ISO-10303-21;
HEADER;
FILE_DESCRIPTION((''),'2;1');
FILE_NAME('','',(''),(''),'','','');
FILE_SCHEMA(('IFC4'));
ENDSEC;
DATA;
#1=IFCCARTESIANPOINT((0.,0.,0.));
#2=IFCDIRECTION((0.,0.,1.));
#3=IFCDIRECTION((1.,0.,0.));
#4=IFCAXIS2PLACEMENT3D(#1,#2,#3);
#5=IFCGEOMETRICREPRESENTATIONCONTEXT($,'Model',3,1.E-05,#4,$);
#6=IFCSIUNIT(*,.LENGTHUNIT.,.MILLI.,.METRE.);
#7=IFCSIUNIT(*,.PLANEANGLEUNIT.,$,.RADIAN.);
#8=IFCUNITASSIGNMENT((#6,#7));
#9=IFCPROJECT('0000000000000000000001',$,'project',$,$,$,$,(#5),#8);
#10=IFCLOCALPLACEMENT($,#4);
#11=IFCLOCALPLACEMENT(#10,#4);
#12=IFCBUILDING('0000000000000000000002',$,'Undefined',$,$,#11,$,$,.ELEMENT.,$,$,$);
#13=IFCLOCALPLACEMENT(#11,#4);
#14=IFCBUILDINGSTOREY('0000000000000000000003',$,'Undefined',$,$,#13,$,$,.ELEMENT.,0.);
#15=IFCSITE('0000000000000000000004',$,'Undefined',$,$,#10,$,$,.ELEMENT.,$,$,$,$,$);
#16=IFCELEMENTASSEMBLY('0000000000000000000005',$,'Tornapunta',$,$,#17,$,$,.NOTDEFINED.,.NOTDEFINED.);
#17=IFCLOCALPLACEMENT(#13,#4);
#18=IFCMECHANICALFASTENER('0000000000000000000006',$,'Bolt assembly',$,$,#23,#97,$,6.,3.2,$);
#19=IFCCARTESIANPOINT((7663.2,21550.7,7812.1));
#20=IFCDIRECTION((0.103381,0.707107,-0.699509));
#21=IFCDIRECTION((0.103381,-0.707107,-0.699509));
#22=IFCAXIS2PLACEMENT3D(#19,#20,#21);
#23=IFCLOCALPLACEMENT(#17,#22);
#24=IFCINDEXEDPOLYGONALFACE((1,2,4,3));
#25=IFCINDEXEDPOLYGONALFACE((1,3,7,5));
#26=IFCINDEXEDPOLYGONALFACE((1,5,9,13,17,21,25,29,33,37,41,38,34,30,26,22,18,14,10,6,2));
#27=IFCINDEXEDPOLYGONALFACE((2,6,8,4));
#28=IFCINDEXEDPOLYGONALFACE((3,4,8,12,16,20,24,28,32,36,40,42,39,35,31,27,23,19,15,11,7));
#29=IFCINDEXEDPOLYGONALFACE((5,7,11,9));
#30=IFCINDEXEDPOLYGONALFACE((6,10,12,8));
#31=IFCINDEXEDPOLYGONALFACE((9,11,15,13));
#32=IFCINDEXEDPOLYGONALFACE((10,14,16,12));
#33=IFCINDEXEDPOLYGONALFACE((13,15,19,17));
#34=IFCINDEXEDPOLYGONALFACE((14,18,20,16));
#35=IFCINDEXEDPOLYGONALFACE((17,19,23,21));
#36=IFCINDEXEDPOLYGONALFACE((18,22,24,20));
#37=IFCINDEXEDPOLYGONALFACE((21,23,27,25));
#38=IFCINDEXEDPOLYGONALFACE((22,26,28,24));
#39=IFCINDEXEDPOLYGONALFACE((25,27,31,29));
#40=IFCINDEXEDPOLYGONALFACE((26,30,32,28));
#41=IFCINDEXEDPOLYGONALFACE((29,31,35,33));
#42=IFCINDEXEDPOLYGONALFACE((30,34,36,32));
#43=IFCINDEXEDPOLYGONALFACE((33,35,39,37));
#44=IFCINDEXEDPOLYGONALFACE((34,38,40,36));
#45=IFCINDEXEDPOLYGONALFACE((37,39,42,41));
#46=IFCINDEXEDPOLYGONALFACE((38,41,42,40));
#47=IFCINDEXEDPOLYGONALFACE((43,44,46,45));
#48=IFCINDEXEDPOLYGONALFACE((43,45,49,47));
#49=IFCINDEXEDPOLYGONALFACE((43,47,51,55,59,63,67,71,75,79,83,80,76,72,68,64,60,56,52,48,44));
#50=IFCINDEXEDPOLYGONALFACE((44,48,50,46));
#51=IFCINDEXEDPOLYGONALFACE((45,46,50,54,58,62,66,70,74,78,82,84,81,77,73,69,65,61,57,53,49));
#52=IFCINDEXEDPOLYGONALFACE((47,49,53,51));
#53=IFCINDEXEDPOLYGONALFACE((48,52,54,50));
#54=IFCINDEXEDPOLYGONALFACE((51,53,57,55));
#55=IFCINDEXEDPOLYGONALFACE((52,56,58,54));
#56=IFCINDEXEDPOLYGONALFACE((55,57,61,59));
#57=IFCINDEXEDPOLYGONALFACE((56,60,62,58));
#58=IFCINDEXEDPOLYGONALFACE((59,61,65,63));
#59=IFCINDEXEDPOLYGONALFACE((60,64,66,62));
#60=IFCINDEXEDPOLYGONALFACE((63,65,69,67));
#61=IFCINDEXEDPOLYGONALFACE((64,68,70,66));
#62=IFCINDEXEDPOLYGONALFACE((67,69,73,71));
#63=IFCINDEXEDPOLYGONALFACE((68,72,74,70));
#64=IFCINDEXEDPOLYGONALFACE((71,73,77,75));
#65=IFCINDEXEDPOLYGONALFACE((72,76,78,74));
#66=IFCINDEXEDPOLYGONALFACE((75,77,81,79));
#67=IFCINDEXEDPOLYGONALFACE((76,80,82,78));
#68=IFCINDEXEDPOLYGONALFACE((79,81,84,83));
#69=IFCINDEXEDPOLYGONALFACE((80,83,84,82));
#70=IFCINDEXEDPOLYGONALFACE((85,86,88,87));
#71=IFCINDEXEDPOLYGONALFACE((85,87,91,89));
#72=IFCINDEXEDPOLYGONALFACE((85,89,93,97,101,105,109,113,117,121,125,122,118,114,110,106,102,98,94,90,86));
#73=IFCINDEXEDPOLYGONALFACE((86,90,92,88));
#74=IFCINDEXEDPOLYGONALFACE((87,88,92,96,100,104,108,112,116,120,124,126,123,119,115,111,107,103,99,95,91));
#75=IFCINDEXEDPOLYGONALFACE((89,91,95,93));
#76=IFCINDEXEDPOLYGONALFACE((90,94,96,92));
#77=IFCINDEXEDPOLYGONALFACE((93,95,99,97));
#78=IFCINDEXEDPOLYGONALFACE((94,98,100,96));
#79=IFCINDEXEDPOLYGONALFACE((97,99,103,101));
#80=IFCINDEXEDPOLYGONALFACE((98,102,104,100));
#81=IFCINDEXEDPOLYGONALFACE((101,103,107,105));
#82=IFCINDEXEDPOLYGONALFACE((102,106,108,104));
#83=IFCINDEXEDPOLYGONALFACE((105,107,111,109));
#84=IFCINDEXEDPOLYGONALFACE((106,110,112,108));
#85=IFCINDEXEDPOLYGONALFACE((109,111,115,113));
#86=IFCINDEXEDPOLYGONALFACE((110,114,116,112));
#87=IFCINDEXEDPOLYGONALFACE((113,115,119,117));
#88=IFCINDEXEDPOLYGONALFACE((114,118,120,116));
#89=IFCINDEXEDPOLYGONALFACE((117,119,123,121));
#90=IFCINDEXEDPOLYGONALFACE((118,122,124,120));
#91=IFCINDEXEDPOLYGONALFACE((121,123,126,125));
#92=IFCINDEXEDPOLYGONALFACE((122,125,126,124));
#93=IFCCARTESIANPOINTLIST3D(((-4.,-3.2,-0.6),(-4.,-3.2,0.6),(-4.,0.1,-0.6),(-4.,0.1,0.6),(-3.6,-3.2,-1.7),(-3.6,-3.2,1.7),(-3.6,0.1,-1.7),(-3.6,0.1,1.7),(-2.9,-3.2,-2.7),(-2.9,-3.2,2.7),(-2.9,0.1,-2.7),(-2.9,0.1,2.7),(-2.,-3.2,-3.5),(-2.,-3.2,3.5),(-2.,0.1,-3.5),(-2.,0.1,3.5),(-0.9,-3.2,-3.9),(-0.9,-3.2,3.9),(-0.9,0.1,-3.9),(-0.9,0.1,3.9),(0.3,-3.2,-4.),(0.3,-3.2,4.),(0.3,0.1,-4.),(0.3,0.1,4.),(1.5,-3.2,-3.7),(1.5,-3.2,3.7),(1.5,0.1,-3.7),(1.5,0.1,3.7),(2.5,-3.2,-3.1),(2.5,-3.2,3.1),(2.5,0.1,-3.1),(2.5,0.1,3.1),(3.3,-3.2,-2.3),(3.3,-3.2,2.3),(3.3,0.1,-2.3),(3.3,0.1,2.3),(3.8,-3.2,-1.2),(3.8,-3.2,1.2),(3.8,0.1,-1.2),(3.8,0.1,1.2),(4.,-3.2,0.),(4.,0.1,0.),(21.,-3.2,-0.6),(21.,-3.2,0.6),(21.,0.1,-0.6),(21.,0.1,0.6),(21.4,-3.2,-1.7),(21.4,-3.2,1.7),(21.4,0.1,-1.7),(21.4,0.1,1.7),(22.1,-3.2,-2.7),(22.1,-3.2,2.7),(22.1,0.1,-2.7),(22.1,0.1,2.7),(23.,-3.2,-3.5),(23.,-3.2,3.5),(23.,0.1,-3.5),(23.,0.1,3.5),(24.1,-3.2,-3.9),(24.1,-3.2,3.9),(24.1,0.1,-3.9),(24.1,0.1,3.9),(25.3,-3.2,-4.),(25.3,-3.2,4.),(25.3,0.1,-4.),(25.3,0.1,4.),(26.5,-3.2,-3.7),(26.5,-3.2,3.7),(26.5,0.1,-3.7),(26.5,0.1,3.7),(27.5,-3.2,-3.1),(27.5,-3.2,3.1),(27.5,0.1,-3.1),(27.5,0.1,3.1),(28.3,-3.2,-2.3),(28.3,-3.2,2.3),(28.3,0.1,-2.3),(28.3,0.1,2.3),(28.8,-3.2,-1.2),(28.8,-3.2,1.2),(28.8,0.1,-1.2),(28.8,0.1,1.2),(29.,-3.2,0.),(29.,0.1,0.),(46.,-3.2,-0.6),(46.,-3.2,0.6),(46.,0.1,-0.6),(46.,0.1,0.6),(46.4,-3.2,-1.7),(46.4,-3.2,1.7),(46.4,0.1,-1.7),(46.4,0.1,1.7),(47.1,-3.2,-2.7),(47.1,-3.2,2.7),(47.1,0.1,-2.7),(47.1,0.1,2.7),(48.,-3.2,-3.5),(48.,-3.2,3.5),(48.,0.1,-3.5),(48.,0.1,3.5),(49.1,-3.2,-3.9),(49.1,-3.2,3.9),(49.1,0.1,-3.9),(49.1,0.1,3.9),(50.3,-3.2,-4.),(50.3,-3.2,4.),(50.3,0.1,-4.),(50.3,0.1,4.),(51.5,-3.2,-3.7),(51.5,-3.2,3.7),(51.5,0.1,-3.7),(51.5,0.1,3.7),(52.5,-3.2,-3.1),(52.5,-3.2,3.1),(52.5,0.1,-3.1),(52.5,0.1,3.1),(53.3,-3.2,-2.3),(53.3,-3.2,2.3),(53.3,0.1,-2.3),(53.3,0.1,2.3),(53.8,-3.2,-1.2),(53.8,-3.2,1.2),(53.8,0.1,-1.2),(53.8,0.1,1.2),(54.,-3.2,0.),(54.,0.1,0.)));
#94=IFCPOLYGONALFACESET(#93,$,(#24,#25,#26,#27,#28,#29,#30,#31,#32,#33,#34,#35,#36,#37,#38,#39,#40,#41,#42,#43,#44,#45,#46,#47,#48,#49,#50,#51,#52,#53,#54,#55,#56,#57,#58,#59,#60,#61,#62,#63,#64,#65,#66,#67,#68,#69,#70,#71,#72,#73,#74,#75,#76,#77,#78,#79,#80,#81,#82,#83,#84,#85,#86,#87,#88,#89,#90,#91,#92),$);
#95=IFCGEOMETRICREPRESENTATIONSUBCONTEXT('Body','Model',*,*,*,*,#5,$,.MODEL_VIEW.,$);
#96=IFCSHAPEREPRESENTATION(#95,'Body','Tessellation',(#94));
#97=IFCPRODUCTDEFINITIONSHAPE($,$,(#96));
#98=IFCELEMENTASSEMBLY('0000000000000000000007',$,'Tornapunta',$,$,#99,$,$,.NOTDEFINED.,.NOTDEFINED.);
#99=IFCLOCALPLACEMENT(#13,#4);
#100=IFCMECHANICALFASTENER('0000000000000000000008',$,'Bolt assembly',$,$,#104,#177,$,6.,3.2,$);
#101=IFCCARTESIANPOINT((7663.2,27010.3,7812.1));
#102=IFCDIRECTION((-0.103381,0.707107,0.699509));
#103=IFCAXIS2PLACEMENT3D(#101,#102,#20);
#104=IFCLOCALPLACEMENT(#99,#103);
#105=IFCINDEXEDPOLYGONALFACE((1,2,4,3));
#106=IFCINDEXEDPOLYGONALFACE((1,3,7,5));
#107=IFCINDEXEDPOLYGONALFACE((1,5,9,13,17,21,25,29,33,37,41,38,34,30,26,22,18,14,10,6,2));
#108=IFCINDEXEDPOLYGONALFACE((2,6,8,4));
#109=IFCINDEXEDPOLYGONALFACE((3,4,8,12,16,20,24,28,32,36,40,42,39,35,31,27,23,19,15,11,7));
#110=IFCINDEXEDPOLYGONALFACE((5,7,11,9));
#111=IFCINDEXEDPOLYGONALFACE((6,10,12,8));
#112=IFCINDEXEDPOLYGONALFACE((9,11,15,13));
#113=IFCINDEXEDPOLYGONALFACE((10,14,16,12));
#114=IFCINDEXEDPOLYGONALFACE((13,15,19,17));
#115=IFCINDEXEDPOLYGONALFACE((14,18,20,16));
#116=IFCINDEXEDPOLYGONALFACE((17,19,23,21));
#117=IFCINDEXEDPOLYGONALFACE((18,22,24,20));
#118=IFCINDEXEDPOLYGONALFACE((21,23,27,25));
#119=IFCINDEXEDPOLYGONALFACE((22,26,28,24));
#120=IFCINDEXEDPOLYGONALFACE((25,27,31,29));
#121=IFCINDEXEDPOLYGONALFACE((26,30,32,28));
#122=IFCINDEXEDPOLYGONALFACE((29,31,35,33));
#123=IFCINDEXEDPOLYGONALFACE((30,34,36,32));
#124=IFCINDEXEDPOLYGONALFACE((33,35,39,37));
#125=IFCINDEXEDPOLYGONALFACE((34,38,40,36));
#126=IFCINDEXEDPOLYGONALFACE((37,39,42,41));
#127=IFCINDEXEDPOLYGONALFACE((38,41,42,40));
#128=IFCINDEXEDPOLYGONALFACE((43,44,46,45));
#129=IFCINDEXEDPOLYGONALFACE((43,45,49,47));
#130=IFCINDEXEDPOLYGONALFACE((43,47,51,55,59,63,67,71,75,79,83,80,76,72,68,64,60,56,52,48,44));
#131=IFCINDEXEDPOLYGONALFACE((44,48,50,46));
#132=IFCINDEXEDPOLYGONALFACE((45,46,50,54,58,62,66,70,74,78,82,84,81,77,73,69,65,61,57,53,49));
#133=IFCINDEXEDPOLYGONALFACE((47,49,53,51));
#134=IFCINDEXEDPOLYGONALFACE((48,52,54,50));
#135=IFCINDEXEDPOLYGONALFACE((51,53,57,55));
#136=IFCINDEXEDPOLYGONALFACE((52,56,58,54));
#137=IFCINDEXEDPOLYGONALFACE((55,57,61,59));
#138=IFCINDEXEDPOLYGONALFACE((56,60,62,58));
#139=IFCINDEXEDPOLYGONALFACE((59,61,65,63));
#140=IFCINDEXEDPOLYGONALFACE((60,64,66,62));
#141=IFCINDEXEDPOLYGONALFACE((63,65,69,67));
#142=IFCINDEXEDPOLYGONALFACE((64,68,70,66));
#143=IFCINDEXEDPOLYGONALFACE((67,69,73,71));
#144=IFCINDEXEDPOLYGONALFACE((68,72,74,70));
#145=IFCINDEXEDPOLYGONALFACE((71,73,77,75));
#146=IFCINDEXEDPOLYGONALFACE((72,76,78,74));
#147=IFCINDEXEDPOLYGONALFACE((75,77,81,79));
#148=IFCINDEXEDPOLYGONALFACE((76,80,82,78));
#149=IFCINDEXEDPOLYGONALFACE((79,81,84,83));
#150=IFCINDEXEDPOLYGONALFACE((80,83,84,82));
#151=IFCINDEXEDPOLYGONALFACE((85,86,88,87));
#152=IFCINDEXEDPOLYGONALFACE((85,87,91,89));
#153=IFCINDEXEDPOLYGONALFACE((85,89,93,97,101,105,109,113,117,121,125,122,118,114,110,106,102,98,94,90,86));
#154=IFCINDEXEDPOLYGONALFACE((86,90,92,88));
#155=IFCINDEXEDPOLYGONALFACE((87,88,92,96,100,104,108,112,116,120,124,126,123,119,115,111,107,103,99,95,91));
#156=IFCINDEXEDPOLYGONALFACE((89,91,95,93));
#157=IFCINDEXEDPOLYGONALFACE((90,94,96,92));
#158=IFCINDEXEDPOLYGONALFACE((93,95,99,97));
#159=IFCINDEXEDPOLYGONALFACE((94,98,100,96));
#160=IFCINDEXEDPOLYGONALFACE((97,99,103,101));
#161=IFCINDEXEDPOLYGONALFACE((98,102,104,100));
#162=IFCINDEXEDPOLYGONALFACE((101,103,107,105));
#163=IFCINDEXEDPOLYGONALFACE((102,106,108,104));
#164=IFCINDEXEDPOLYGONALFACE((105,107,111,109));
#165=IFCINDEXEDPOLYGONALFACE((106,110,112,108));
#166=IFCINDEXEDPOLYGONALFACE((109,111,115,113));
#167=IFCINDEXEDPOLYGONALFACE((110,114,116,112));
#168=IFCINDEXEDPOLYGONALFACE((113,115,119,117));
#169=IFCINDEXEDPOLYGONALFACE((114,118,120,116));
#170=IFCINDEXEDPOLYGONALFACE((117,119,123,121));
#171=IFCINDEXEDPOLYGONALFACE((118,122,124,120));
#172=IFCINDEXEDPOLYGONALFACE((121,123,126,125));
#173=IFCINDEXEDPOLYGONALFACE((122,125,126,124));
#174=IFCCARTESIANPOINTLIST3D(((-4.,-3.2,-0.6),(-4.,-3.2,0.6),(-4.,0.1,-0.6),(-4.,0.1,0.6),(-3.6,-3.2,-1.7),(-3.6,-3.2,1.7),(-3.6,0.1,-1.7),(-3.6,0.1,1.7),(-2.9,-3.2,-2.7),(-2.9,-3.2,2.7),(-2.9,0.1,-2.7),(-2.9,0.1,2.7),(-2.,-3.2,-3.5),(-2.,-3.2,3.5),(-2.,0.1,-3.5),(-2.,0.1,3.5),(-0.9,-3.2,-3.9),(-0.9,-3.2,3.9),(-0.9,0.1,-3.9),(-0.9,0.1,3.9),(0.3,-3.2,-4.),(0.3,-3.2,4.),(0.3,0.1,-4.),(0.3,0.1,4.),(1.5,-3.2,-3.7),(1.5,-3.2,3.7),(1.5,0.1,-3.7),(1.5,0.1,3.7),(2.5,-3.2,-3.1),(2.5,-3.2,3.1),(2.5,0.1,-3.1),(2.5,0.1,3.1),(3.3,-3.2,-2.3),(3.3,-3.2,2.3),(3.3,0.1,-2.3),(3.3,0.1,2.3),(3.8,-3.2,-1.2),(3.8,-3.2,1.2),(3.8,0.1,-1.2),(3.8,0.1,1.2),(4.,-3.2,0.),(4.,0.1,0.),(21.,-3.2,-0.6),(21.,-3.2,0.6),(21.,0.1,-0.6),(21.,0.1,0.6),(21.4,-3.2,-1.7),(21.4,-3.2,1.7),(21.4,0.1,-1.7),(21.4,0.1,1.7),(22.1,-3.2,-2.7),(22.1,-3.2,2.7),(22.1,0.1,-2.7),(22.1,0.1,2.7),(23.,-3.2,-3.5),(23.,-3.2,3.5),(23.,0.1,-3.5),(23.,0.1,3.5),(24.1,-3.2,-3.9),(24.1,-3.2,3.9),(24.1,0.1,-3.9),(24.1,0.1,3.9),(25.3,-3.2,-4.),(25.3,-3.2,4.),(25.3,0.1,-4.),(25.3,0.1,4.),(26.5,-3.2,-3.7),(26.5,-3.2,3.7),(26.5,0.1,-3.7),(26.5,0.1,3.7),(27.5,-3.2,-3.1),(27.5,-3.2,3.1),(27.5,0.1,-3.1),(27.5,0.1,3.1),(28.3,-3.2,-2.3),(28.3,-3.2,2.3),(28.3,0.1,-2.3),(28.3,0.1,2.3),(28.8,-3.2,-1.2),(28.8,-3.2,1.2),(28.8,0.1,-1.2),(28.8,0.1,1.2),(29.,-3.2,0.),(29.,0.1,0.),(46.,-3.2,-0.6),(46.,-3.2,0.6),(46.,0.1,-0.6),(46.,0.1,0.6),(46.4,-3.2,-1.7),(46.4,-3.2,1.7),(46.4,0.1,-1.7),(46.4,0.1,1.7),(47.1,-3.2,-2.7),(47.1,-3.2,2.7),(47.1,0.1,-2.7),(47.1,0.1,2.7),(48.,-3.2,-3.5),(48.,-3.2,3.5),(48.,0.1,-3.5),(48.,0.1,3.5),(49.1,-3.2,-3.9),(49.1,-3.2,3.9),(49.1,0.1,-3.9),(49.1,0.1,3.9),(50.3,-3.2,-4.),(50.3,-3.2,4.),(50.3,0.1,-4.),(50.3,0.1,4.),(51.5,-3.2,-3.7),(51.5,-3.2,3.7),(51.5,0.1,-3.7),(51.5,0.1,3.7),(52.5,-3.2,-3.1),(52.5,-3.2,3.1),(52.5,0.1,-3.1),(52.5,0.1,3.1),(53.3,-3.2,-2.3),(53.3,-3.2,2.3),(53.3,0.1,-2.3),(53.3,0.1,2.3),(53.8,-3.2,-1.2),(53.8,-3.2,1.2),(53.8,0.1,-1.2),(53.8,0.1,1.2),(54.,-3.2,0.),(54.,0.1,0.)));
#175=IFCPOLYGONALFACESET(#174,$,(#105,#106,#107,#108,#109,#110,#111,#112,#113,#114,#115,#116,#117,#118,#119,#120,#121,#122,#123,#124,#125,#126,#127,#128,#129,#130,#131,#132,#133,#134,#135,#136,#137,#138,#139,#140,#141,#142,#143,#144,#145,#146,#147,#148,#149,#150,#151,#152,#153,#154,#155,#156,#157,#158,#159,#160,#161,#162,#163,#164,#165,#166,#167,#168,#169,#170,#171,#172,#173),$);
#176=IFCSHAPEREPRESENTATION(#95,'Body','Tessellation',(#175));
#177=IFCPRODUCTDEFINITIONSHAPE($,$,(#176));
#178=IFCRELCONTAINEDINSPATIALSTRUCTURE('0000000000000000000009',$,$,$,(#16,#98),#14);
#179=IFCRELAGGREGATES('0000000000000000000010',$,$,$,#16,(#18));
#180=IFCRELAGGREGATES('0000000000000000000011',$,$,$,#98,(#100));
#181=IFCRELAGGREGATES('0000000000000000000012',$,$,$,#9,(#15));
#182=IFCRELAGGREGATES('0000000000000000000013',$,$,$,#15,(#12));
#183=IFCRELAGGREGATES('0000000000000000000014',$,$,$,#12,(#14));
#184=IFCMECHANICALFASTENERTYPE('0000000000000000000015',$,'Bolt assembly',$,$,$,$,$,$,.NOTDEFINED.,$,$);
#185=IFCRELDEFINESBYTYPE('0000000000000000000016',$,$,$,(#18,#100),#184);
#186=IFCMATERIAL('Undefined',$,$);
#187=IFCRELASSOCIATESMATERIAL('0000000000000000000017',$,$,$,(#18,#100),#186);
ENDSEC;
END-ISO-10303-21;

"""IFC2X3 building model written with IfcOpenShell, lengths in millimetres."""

from ifc_helpers import new_model, si_unit, frame, origin_with_axes, origin_2d_with_axis, place, context, subcontext, project, spatial, circle, extrude, source, transform, mapped, material, type_object, element, aggregate, save


model = new_model("IFC2X3")

# Units and contexts
model_context = context("Model", 3, precision=1e-05, world=origin_with_axes())
body_context = subcontext(model_context, "Body", "Model", "MODEL_VIEW")
ifc_project = project(units=[si_unit("LENGTHUNIT", "METRE", prefix="MILLI"), si_unit("PLANEANGLEUNIT", "RADIAN")], contexts=[model_context])

# Site, building, storey
site_placement = place(None, origin_with_axes())
site = spatial("IfcSite", under=ifc_project, at=site_placement, Name="Undefined", CompositionType="ELEMENT")
building_placement = place(site_placement, origin_with_axes())
building = spatial("IfcBuilding", under=site, at=building_placement, Name="Undefined", CompositionType="ELEMENT")
storey_placement = place(building_placement, origin_with_axes())
storey = spatial("IfcBuildingStorey", under=building, at=storey_placement, Name="Undefined", CompositionType="ELEMENT", Elevation=0.0)

# Shared definitions
ifc_material_1 = material(Name="Undefined")
mechanical_fastener_type = type_object("IfcMechanicalFastenerType", Name="Bolt assembly")

# Element assemblies, mechanical fasteners
shared_shape_1 = source(origin_with_axes(), body_context, "Body", "SweptSolid", [
    extrude(circle(Radius=4.0, at=origin_2d_with_axis()), frame((0.0, -3.2, 0.0), z_axis=(0.0, 1.0, 0.0), x_axis=(1.0, 0.0, 0.0)), (0.0, 0.0, 1.0), 3.3),
])
assembly_1_placement = place(storey_placement, origin_with_axes())
assembly_1 = element("IfcElementAssembly", 1, at=assembly_1_placement, inside=storey, Name="Tornapunta", AssemblyPlace="NOTDEFINED", PredefinedType="NOTDEFINED")
mechanical_fastener_1_placement = place(assembly_1_placement, frame((7663.2, 21550.7, 7812.1), z_axis=(0.103381, 0.707107, -0.699509), x_axis=(0.103381, -0.707107, -0.699509)))
mechanical_fastener_1 = element("IfcMechanicalFastener", 2, at=mechanical_fastener_1_placement, type_object=mechanical_fastener_type, material=ifc_material_1, Name="Bolt assembly", NominalDiameter=6.0, NominalLength=3.2, context=body_context, shape_type="MappedRepresentation", body=[
    mapped(shared_shape_1, transform((0.0, 0.0, 0.0))),
    mapped(shared_shape_1, transform((25.0, 0.0, 0.0))),
    mapped(shared_shape_1, transform((50.0, 0.0, 0.0))),
])
aggregate(assembly_1, [mechanical_fastener_1])
assembly_2_placement = place(storey_placement, origin_with_axes())
assembly_2 = element("IfcElementAssembly", 3, at=assembly_2_placement, inside=storey, Name="Tornapunta", AssemblyPlace="NOTDEFINED", PredefinedType="NOTDEFINED")
mechanical_fastener_2_placement = place(assembly_2_placement, frame((7663.2, 27010.3, 7812.1), z_axis=(-0.103381, 0.707107, 0.699509), x_axis=(0.103381, 0.707107, -0.699509)))
mechanical_fastener_2 = element("IfcMechanicalFastener", 4, at=mechanical_fastener_2_placement, type_object=mechanical_fastener_type, material=ifc_material_1, Name="Bolt assembly", NominalDiameter=6.0, NominalLength=3.2, context=body_context, shape_type="MappedRepresentation", body=[
    mapped(shared_shape_1, transform((0.0, 0.0, 0.0))),
    mapped(shared_shape_1, transform((25.0, 0.0, 0.0))),
    mapped(shared_shape_1, transform((50.0, 0.0, 0.0))),
])
aggregate(assembly_2, [mechanical_fastener_2])

save(model, "model.ifc")
